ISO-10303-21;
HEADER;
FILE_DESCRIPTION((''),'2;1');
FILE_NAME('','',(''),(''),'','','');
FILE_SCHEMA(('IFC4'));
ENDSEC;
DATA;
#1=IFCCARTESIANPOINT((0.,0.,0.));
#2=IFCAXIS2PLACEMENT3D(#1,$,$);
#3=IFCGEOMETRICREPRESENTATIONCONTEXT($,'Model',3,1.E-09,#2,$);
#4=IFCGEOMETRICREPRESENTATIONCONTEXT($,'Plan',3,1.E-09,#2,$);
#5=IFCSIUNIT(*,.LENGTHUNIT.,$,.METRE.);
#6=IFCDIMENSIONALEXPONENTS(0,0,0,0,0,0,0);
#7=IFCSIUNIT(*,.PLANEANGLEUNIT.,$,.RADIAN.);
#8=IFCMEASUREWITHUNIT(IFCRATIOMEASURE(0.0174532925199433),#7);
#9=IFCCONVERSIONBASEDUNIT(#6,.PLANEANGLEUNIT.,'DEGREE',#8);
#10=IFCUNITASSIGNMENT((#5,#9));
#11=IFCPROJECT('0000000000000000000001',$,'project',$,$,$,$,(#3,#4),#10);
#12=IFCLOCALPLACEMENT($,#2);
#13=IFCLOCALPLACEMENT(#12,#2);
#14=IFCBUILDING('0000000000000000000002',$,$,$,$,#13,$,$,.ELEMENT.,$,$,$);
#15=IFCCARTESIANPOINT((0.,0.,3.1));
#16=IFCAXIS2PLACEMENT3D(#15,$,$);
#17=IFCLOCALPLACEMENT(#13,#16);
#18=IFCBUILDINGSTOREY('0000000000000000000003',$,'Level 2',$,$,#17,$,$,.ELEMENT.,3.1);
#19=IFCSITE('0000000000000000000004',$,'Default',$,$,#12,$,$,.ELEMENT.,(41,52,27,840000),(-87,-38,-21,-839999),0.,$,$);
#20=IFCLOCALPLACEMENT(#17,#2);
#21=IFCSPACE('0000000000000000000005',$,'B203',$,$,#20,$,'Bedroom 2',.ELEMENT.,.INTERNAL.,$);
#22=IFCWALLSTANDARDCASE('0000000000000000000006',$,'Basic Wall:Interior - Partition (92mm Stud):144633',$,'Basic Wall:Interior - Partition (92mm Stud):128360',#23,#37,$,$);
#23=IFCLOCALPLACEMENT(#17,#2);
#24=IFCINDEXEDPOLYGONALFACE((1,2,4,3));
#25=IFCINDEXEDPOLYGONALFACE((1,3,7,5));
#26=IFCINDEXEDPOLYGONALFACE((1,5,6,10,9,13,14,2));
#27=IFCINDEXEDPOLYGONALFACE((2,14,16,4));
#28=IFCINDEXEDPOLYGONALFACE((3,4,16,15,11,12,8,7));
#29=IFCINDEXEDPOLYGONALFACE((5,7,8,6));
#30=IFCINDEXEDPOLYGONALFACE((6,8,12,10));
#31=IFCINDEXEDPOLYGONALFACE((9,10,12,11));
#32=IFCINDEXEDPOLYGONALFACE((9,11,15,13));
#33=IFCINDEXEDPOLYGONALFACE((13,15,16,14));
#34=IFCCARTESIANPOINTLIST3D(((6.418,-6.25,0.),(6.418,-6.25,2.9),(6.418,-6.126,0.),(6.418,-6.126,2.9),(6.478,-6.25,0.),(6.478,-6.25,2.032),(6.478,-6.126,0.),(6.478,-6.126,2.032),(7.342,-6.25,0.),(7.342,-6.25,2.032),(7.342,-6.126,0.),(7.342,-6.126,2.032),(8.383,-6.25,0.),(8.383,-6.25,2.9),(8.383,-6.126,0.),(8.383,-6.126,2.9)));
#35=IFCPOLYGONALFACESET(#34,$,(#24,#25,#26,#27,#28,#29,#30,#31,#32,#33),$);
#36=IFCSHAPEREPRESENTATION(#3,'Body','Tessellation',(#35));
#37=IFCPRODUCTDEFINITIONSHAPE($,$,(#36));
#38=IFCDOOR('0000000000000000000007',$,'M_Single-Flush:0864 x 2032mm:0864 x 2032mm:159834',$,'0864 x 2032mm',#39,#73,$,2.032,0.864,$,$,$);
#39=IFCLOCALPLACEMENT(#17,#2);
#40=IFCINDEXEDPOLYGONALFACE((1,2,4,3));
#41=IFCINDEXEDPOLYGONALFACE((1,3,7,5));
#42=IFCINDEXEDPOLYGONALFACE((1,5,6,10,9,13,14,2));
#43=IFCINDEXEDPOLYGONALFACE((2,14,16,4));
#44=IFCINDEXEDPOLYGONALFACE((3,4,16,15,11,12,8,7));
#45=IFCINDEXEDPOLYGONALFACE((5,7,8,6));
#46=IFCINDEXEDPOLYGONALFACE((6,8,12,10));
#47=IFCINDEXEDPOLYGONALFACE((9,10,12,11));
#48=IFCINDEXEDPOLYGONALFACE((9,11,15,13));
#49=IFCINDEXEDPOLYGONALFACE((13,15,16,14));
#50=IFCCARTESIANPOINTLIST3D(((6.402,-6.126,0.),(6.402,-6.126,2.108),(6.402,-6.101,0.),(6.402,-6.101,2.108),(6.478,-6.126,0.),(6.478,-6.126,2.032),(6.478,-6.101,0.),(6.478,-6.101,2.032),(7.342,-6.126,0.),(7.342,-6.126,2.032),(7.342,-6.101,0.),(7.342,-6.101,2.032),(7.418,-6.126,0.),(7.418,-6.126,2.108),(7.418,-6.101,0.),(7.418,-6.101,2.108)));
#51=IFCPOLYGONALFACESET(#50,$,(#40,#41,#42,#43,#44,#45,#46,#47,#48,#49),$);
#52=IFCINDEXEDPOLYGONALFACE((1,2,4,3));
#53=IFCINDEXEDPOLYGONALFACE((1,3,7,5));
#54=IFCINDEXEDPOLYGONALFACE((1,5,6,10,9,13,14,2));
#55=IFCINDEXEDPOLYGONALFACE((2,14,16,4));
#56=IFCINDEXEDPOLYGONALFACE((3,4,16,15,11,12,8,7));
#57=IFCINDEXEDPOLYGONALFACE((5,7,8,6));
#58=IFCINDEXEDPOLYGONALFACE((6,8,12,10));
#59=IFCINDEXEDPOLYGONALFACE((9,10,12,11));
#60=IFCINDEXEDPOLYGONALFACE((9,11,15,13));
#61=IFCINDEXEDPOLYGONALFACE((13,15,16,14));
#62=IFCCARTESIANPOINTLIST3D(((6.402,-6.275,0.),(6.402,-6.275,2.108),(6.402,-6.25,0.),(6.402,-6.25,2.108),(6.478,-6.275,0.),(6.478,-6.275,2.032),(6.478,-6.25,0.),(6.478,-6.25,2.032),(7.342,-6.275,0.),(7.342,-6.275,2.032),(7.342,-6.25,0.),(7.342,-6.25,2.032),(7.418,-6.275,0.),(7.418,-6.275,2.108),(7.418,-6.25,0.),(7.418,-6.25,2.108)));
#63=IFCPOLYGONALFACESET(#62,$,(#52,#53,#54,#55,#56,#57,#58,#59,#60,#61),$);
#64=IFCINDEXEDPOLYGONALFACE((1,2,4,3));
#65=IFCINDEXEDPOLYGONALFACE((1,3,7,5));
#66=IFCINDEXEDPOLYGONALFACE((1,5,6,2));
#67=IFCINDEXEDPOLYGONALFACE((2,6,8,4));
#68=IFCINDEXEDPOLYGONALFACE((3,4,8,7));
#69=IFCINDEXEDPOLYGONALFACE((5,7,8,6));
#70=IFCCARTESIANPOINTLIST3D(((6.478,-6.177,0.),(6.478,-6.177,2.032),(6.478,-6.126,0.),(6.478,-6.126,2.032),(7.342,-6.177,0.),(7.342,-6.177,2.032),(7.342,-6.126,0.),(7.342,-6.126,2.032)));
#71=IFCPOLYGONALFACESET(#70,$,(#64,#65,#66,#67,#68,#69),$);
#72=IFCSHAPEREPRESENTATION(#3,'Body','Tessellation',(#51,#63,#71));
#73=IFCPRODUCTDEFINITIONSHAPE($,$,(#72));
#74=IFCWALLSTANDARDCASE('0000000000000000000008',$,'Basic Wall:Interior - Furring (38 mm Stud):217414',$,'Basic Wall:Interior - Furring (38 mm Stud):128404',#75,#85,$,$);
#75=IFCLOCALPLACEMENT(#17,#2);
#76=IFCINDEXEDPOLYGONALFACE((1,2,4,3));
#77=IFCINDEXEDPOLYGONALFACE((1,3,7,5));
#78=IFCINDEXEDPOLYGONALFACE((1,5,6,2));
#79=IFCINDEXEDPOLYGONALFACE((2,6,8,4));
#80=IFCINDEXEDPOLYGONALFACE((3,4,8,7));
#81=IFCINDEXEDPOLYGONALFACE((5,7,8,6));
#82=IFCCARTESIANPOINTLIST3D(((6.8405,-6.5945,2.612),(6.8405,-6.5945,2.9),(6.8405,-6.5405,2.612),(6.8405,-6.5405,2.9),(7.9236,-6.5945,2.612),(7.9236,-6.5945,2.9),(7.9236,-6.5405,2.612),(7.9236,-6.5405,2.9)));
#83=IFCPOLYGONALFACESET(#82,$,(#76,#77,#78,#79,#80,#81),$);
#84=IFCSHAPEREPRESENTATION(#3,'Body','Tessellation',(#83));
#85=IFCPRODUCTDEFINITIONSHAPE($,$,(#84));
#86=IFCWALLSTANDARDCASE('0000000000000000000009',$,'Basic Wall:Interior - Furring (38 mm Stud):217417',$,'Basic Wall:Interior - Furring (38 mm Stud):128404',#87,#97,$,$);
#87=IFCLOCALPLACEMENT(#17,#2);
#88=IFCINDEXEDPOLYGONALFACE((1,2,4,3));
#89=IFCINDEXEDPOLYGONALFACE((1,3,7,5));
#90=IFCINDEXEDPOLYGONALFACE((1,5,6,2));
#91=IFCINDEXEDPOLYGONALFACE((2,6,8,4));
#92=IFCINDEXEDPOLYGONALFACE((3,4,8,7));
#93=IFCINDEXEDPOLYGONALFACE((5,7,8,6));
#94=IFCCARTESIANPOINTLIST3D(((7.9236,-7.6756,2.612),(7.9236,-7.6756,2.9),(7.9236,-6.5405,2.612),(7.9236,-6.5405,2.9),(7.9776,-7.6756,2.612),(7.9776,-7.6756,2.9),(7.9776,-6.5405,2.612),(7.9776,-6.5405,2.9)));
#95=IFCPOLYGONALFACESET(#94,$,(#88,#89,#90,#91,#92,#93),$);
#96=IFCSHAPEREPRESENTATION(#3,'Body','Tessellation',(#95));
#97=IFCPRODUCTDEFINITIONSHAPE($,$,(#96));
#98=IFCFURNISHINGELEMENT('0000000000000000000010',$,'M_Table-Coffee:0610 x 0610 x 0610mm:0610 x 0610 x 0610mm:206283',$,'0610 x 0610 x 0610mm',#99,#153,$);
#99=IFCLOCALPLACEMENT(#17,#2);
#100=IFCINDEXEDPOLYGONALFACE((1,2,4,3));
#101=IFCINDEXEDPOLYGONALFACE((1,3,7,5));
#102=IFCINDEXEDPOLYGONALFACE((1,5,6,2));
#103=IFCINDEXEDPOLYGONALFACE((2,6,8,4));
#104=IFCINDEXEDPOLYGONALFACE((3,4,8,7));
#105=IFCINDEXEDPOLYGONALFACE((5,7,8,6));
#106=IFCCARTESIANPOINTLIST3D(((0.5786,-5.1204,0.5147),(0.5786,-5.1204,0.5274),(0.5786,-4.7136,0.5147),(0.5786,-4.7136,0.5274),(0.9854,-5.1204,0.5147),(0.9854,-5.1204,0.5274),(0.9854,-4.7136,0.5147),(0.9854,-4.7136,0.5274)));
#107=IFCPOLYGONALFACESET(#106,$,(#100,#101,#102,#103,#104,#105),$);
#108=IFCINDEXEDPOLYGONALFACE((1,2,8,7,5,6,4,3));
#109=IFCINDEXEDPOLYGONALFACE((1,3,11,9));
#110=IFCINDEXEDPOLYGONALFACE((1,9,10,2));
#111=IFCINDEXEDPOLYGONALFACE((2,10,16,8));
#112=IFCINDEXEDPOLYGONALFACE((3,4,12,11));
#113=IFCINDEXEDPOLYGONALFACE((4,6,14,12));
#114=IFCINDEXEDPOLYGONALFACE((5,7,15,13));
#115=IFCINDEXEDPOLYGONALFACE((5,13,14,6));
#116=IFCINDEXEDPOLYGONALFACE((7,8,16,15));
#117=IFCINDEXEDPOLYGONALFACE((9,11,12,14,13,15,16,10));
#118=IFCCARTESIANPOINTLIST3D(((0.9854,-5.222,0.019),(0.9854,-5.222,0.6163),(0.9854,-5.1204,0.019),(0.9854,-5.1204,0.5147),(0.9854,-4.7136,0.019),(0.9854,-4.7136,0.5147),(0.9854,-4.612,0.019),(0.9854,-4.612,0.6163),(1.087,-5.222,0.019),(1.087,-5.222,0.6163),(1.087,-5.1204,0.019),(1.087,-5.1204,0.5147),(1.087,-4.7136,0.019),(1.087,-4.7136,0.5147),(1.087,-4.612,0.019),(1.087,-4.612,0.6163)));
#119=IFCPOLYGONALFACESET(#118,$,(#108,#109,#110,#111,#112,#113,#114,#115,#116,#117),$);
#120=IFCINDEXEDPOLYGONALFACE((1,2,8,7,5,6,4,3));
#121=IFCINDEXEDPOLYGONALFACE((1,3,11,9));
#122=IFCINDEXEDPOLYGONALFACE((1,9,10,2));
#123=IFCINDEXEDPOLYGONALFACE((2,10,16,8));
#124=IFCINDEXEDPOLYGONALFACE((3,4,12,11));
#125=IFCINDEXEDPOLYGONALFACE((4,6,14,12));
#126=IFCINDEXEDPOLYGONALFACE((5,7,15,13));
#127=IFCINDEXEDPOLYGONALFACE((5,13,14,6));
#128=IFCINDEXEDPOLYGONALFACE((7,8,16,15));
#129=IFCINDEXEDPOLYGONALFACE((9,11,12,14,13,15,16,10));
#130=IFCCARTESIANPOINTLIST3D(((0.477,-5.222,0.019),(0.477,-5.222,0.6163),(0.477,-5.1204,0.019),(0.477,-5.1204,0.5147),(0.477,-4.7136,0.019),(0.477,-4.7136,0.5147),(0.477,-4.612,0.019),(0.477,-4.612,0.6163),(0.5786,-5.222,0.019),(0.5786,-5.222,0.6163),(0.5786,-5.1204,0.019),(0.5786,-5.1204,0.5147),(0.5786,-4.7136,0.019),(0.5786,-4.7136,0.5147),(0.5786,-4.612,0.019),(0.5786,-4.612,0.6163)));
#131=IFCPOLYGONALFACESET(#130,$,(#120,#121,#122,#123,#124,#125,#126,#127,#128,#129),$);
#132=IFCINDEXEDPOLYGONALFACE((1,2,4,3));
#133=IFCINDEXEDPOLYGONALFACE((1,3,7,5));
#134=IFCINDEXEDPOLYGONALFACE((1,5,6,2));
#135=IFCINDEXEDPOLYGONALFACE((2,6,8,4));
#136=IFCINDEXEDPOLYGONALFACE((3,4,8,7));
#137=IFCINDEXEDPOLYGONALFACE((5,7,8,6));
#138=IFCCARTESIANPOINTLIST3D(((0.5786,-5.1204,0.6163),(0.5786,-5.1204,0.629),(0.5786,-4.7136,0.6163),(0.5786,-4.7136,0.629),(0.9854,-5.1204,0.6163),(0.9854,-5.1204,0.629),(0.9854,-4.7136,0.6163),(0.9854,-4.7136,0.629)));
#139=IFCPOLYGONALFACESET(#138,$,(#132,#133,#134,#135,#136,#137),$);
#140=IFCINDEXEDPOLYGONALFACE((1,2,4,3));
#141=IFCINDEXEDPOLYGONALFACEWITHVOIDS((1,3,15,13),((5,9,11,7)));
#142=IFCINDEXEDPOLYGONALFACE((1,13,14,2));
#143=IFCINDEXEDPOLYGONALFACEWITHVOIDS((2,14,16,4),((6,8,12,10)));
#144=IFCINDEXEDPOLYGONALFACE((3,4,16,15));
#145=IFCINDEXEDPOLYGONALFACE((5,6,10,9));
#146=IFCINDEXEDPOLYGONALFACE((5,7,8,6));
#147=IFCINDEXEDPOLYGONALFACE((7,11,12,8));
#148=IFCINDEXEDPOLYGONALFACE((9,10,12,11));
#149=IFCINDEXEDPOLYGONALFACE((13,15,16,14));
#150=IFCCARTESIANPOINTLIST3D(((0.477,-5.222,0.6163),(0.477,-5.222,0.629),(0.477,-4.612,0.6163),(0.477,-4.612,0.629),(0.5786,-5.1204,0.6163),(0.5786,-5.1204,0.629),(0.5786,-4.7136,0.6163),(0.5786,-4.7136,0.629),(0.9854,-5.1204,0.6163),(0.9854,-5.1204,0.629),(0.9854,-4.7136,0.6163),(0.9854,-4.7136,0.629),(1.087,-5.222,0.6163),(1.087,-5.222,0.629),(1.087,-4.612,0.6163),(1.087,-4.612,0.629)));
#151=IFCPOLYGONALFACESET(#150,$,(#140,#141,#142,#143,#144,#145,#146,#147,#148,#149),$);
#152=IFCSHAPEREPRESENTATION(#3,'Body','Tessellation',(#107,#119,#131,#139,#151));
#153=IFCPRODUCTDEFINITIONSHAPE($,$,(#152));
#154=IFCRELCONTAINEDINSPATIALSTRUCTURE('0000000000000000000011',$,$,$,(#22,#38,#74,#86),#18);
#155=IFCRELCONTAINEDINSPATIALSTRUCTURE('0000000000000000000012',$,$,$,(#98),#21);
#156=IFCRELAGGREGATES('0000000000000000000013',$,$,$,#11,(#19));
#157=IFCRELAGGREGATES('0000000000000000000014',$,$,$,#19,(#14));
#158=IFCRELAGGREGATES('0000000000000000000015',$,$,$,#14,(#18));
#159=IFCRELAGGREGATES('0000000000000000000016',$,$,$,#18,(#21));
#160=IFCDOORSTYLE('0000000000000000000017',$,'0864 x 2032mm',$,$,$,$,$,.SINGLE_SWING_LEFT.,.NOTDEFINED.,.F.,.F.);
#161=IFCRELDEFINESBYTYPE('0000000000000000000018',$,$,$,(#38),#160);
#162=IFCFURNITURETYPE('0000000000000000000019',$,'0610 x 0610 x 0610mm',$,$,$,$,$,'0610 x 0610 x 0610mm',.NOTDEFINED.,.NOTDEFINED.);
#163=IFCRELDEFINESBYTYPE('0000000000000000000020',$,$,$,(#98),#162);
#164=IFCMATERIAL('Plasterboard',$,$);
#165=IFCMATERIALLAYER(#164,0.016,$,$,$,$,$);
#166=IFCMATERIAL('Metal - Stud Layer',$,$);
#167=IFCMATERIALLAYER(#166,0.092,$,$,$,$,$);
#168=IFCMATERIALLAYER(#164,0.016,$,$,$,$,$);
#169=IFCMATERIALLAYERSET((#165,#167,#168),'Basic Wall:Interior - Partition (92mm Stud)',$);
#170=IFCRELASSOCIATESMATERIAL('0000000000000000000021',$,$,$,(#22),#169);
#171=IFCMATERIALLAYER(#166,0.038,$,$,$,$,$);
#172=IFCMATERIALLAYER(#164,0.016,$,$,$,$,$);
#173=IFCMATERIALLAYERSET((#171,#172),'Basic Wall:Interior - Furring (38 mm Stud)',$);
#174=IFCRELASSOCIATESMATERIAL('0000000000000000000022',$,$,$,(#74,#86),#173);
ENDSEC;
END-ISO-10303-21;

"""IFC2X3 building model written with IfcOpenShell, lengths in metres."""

from ifc_helpers import new_model, entity, si_unit, converted_unit, frame, frame_2d, origin, origin_2d_with_axis, place, context, project, spatial, polyline, rectangle, outline, extrude, source, transform, mapped, material, layer, layer_set, layer_usage, type_object, type_shapes, element, fill, save


model = new_model("IFC2X3")

# Units and contexts
model_context = context("Model", 3, precision=1e-09, world=origin())
plan_context = context("Plan", 3, precision=1e-09, world=origin())
ifc_project = project(units=[si_unit("LENGTHUNIT", "METRE"), converted_unit("PLANEANGLEUNIT", "DEGREE", entity("IfcRatioMeasure", 0.0174532925199433), si_unit("PLANEANGLEUNIT", "RADIAN"), dimensions=[0, 0, 0, 0, 0, 0, 0])], contexts=[model_context, plan_context])

# Site, building, storey
site_placement = place(None, origin())
site = spatial("IfcSite", under=ifc_project, at=site_placement, Name="Default", CompositionType="ELEMENT", RefLatitude=(41, 52, 27, 840000), RefLongitude=(-87, -38, -21, -839999), RefElevation=0.0)
building_placement = place(site_placement, origin())
building = spatial("IfcBuilding", under=site, at=building_placement, CompositionType="ELEMENT")
storey_placement = place(building_placement, frame((0.0, 0.0, 3.1)))
storey = spatial("IfcBuildingStorey", under=building, at=storey_placement, Name="Level 2", CompositionType="ELEMENT", Elevation=3.1)

# Shared definitions
ifc_material_1 = material(Name="Metal - Stud Layer")
ifc_material_2 = material(Name="Plasterboard")

# Wall, opening, door
ifc_layer_1 = layer(ifc_material_2, 0.016)
ifc_layer_2 = layer(ifc_material_1, 0.092)
ifc_layer_3 = layer(ifc_material_2, 0.016)
ifc_layer_set_1 = layer_set([ifc_layer_1, ifc_layer_2, ifc_layer_3], Name="Basic Wall:Interior - Partition (92mm Stud)")
ifc_layer_usage_1 = layer_usage(ifc_layer_set_1, "AXIS2", "NEGATIVE", 0.062)
wall_1_placement = place(storey_placement, frame((6.418, -6.188, 0.0)))
wall_1 = element("IfcWallStandardCase", 1, at=wall_1_placement, inside=storey, material=ifc_layer_usage_1, Name="Basic Wall:Interior - Partition (92mm Stud):144633", ObjectType="Basic Wall:Interior - Partition (92mm Stud):128360", context=model_context, shape_type="SweptSolid", body=[
    extrude(rectangle(XDim=1.965, YDim=0.124, at=frame_2d((0.9825, 0.0), x_axis=(-1.0, 0.0))), origin(), (0.0, 0.0, 1.0), 2.9),
])
opening_1_placement = place(wall_1_placement, frame((0.06, -0.062, 0.0)))
opening_1 = element("IfcOpeningElement", 2, at=opening_1_placement, cuts=wall_1, ObjectType="Opening", context=model_context, shape_type="SweptSolid", body=[
    extrude(rectangle(XDim=0.864, YDim=2.032, at=frame_2d((1.016, 0.432), x_axis=(0.0, -1.0))), frame((0.0, 0.0, 0.0), z_axis=(0.0, 1.0, 0.0), x_axis=(0.0, 0.0, 1.0)), (0.0, 0.0, 1.0), 0.124),
])
door_style_1 = type_object("IfcDoorStyle", Name="0864 x 2032mm", ConstructionType="NOTDEFINED", OperationType="SINGLE_SWING_LEFT", ParameterTakesPrecedence=False, Sizeable=False)
shared_shape_1 = source(origin(), model_context, "Body", "SweptSolid", [
    extrude(outline(polyline([(-0.508, -1.073), (0.508, -1.073), (0.508, 1.035), (0.432, 1.035), (0.432, -0.997), (-0.432, -0.997), (-0.432, 1.035), (-0.508, 1.035), (-0.508, -1.073)])), frame((0.432, 0.149, 1.035), z_axis=(0.0, -1.0, 0.0), x_axis=(-1.0, 0.0, 0.0)), (0.0, 0.0, 1.0), 0.025),
    extrude(outline(polyline([(-1.073, -0.508), (1.035, -0.508), (1.035, -0.432), (-0.997, -0.432), (-0.997, 0.432), (1.035, 0.432), (1.035, 0.508), (-1.073, 0.508), (-1.073, -0.508)])), frame((0.432, 0.0, 1.035), z_axis=(0.0, -1.0, 0.0), x_axis=(0.0, 0.0, -1.0)), (0.0, 0.0, 1.0), 0.025),
    extrude(rectangle(XDim=0.864, YDim=0.051, at=origin_2d_with_axis()), frame((0.432, 0.0985, 0.0)), (0.0, 0.0, 1.0), 2.032),
])
type_shapes(door_style_1, [shared_shape_1])
door_1_placement = place(opening_1_placement, origin())
door_1 = element("IfcDoor", 3, at=door_1_placement, inside=storey, type_object=door_style_1, Name="M_Single-Flush:0864 x 2032mm:0864 x 2032mm:159834", ObjectType="0864 x 2032mm", OverallHeight=2.032, OverallWidth=0.864, context=model_context, shape_type="MappedRepresentation", body=[
    mapped(shared_shape_1, transform((0.0, 0.0, 0.0), scale=1.0)),
])
fill(opening_1, door_1)

# Walls
ifc_layer_4 = layer(ifc_material_1, 0.038)
ifc_layer_5 = layer(ifc_material_2, 0.016)
ifc_layer_set_2 = layer_set([ifc_layer_4, ifc_layer_5], Name="Basic Wall:Interior - Furring (38 mm Stud)")
ifc_layer_usage_2 = layer_usage(ifc_layer_set_2, "AXIS2", "NEGATIVE", 0.027)
wall_2_placement = place(storey_placement, frame((6.8405, -6.5675, 2.612)))
element("IfcWallStandardCase", 4, at=wall_2_placement, inside=storey, material=ifc_layer_usage_2, Name="Basic Wall:Interior - Furring (38 mm Stud):217414", ObjectType="Basic Wall:Interior - Furring (38 mm Stud):128404", context=model_context, shape_type="SweptSolid", body=[
    extrude(rectangle(XDim=1.0831, YDim=0.054, at=frame_2d((0.5415, 0.0), x_axis=(-1.0, 0.0))), origin(), (0.0, 0.0, 1.0), 0.288),
])
ifc_layer_usage_3 = layer_usage(ifc_layer_set_2, "AXIS2", "NEGATIVE", 0.027)
wall_3_placement = place(storey_placement, frame((7.9506, -6.5405, 2.612), z_axis=(0.0, 0.0, 1.0), x_axis=(0.0, -1.0, 0.0)))
element("IfcWallStandardCase", 5, at=wall_3_placement, inside=storey, material=ifc_layer_usage_3, Name="Basic Wall:Interior - Furring (38 mm Stud):217417", ObjectType="Basic Wall:Interior - Furring (38 mm Stud):128404", context=model_context, shape_type="SweptSolid", body=[
    extrude(rectangle(XDim=1.1351, YDim=0.054, at=frame_2d((0.5675, 0.0), x_axis=(-1.0, 0.0))), origin(), (0.0, 0.0, 1.0), 0.288),
])

# Shared definitions
space_1_placement = place(storey_placement, origin())
space_1 = spatial("IfcSpace", under=storey, at=space_1_placement, Name="B203", LongName="Bedroom 2", CompositionType="ELEMENT", InteriorOrExteriorSpace="INTERNAL")

# Furnishing element
furniture_type = type_object("IfcFurnitureType", Name="0610 x 0610 x 0610mm", ElementType="0610 x 0610 x 0610mm", AssemblyPlace="NOTDEFINED")
shared_shape_2 = source(origin(), model_context, "Body", "SweptSolid", [
    extrude(rectangle(XDim=0.4068, YDim=0.4068, at=origin_2d_with_axis()), frame((0.0183, 0.0952, 0.4957), z_axis=(0.0, 0.0, 1.0), x_axis=(-1.0, 0.0, 0.0)), (0.0, 0.0, 1.0), 0.0127),
    extrude(outline(polyline([(-0.2732, -0.305), (0.324, -0.305), (0.324, 0.305), (-0.2732, 0.305), (-0.2732, 0.2034), (0.2225, 0.2034), (0.2225, -0.2034), (-0.2732, -0.2034), (-0.2732, -0.305)])), frame((0.2217, 0.0952, 0.2732), z_axis=(1.0, 0.0, 0.0), x_axis=(0.0, 0.0, 1.0)), (0.0, 0.0, 1.0), 0.1016),
    extrude(outline(polyline([(-0.305, -0.3241), (0.305, -0.3241), (0.305, 0.2733), (0.2034, 0.2733), (0.2034, -0.2224), (-0.2034, -0.2224), (-0.2034, 0.2733), (-0.305, 0.2733), (-0.305, -0.3241)])), frame((-0.2867, 0.0952, 0.2733), z_axis=(1.0, 0.0, 0.0), x_axis=(0.0, -1.0, 0.0)), (0.0, 0.0, 1.0), 0.1016),
    extrude(rectangle(XDim=0.4068, YDim=0.4068, at=origin_2d_with_axis()), frame((0.0183, 0.0952, 0.5973), z_axis=(0.0, 0.0, 1.0), x_axis=(-1.0, 0.0, 0.0)), (0.0, 0.0, 1.0), 0.0127),
    extrude(outline(polyline([(-0.305, -0.305), (0.305, -0.305), (0.305, 0.305), (-0.305, 0.305), (-0.305, -0.305)]), holes=[polyline([(-0.2034, -0.2034), (-0.2034, 0.2034), (0.2034, 0.2034), (0.2034, -0.2034), (-0.2034, -0.2034)])]), frame((0.0183, 0.0952, 0.5973), z_axis=(0.0, 0.0, 1.0), x_axis=(-1.0, 0.0, 0.0)), (0.0, 0.0, 1.0), 0.0127),
])
type_shapes(furniture_type, [shared_shape_2])
furnishing_1_placement = place(space_1_placement, frame((0.7637, -5.0122, 0.019)))
element("IfcFurnishingElement", 6, at=furnishing_1_placement, inside=space_1, type_object=furniture_type, Name="M_Table-Coffee:0610 x 0610 x 0610mm:0610 x 0610 x 0610mm:206283", ObjectType="0610 x 0610 x 0610mm", context=model_context, shape_type="MappedRepresentation", body=[
    mapped(shared_shape_2, transform((0.0, 0.0, 0.0), scale=1.0)),
])

save(model, "model.ifc")
